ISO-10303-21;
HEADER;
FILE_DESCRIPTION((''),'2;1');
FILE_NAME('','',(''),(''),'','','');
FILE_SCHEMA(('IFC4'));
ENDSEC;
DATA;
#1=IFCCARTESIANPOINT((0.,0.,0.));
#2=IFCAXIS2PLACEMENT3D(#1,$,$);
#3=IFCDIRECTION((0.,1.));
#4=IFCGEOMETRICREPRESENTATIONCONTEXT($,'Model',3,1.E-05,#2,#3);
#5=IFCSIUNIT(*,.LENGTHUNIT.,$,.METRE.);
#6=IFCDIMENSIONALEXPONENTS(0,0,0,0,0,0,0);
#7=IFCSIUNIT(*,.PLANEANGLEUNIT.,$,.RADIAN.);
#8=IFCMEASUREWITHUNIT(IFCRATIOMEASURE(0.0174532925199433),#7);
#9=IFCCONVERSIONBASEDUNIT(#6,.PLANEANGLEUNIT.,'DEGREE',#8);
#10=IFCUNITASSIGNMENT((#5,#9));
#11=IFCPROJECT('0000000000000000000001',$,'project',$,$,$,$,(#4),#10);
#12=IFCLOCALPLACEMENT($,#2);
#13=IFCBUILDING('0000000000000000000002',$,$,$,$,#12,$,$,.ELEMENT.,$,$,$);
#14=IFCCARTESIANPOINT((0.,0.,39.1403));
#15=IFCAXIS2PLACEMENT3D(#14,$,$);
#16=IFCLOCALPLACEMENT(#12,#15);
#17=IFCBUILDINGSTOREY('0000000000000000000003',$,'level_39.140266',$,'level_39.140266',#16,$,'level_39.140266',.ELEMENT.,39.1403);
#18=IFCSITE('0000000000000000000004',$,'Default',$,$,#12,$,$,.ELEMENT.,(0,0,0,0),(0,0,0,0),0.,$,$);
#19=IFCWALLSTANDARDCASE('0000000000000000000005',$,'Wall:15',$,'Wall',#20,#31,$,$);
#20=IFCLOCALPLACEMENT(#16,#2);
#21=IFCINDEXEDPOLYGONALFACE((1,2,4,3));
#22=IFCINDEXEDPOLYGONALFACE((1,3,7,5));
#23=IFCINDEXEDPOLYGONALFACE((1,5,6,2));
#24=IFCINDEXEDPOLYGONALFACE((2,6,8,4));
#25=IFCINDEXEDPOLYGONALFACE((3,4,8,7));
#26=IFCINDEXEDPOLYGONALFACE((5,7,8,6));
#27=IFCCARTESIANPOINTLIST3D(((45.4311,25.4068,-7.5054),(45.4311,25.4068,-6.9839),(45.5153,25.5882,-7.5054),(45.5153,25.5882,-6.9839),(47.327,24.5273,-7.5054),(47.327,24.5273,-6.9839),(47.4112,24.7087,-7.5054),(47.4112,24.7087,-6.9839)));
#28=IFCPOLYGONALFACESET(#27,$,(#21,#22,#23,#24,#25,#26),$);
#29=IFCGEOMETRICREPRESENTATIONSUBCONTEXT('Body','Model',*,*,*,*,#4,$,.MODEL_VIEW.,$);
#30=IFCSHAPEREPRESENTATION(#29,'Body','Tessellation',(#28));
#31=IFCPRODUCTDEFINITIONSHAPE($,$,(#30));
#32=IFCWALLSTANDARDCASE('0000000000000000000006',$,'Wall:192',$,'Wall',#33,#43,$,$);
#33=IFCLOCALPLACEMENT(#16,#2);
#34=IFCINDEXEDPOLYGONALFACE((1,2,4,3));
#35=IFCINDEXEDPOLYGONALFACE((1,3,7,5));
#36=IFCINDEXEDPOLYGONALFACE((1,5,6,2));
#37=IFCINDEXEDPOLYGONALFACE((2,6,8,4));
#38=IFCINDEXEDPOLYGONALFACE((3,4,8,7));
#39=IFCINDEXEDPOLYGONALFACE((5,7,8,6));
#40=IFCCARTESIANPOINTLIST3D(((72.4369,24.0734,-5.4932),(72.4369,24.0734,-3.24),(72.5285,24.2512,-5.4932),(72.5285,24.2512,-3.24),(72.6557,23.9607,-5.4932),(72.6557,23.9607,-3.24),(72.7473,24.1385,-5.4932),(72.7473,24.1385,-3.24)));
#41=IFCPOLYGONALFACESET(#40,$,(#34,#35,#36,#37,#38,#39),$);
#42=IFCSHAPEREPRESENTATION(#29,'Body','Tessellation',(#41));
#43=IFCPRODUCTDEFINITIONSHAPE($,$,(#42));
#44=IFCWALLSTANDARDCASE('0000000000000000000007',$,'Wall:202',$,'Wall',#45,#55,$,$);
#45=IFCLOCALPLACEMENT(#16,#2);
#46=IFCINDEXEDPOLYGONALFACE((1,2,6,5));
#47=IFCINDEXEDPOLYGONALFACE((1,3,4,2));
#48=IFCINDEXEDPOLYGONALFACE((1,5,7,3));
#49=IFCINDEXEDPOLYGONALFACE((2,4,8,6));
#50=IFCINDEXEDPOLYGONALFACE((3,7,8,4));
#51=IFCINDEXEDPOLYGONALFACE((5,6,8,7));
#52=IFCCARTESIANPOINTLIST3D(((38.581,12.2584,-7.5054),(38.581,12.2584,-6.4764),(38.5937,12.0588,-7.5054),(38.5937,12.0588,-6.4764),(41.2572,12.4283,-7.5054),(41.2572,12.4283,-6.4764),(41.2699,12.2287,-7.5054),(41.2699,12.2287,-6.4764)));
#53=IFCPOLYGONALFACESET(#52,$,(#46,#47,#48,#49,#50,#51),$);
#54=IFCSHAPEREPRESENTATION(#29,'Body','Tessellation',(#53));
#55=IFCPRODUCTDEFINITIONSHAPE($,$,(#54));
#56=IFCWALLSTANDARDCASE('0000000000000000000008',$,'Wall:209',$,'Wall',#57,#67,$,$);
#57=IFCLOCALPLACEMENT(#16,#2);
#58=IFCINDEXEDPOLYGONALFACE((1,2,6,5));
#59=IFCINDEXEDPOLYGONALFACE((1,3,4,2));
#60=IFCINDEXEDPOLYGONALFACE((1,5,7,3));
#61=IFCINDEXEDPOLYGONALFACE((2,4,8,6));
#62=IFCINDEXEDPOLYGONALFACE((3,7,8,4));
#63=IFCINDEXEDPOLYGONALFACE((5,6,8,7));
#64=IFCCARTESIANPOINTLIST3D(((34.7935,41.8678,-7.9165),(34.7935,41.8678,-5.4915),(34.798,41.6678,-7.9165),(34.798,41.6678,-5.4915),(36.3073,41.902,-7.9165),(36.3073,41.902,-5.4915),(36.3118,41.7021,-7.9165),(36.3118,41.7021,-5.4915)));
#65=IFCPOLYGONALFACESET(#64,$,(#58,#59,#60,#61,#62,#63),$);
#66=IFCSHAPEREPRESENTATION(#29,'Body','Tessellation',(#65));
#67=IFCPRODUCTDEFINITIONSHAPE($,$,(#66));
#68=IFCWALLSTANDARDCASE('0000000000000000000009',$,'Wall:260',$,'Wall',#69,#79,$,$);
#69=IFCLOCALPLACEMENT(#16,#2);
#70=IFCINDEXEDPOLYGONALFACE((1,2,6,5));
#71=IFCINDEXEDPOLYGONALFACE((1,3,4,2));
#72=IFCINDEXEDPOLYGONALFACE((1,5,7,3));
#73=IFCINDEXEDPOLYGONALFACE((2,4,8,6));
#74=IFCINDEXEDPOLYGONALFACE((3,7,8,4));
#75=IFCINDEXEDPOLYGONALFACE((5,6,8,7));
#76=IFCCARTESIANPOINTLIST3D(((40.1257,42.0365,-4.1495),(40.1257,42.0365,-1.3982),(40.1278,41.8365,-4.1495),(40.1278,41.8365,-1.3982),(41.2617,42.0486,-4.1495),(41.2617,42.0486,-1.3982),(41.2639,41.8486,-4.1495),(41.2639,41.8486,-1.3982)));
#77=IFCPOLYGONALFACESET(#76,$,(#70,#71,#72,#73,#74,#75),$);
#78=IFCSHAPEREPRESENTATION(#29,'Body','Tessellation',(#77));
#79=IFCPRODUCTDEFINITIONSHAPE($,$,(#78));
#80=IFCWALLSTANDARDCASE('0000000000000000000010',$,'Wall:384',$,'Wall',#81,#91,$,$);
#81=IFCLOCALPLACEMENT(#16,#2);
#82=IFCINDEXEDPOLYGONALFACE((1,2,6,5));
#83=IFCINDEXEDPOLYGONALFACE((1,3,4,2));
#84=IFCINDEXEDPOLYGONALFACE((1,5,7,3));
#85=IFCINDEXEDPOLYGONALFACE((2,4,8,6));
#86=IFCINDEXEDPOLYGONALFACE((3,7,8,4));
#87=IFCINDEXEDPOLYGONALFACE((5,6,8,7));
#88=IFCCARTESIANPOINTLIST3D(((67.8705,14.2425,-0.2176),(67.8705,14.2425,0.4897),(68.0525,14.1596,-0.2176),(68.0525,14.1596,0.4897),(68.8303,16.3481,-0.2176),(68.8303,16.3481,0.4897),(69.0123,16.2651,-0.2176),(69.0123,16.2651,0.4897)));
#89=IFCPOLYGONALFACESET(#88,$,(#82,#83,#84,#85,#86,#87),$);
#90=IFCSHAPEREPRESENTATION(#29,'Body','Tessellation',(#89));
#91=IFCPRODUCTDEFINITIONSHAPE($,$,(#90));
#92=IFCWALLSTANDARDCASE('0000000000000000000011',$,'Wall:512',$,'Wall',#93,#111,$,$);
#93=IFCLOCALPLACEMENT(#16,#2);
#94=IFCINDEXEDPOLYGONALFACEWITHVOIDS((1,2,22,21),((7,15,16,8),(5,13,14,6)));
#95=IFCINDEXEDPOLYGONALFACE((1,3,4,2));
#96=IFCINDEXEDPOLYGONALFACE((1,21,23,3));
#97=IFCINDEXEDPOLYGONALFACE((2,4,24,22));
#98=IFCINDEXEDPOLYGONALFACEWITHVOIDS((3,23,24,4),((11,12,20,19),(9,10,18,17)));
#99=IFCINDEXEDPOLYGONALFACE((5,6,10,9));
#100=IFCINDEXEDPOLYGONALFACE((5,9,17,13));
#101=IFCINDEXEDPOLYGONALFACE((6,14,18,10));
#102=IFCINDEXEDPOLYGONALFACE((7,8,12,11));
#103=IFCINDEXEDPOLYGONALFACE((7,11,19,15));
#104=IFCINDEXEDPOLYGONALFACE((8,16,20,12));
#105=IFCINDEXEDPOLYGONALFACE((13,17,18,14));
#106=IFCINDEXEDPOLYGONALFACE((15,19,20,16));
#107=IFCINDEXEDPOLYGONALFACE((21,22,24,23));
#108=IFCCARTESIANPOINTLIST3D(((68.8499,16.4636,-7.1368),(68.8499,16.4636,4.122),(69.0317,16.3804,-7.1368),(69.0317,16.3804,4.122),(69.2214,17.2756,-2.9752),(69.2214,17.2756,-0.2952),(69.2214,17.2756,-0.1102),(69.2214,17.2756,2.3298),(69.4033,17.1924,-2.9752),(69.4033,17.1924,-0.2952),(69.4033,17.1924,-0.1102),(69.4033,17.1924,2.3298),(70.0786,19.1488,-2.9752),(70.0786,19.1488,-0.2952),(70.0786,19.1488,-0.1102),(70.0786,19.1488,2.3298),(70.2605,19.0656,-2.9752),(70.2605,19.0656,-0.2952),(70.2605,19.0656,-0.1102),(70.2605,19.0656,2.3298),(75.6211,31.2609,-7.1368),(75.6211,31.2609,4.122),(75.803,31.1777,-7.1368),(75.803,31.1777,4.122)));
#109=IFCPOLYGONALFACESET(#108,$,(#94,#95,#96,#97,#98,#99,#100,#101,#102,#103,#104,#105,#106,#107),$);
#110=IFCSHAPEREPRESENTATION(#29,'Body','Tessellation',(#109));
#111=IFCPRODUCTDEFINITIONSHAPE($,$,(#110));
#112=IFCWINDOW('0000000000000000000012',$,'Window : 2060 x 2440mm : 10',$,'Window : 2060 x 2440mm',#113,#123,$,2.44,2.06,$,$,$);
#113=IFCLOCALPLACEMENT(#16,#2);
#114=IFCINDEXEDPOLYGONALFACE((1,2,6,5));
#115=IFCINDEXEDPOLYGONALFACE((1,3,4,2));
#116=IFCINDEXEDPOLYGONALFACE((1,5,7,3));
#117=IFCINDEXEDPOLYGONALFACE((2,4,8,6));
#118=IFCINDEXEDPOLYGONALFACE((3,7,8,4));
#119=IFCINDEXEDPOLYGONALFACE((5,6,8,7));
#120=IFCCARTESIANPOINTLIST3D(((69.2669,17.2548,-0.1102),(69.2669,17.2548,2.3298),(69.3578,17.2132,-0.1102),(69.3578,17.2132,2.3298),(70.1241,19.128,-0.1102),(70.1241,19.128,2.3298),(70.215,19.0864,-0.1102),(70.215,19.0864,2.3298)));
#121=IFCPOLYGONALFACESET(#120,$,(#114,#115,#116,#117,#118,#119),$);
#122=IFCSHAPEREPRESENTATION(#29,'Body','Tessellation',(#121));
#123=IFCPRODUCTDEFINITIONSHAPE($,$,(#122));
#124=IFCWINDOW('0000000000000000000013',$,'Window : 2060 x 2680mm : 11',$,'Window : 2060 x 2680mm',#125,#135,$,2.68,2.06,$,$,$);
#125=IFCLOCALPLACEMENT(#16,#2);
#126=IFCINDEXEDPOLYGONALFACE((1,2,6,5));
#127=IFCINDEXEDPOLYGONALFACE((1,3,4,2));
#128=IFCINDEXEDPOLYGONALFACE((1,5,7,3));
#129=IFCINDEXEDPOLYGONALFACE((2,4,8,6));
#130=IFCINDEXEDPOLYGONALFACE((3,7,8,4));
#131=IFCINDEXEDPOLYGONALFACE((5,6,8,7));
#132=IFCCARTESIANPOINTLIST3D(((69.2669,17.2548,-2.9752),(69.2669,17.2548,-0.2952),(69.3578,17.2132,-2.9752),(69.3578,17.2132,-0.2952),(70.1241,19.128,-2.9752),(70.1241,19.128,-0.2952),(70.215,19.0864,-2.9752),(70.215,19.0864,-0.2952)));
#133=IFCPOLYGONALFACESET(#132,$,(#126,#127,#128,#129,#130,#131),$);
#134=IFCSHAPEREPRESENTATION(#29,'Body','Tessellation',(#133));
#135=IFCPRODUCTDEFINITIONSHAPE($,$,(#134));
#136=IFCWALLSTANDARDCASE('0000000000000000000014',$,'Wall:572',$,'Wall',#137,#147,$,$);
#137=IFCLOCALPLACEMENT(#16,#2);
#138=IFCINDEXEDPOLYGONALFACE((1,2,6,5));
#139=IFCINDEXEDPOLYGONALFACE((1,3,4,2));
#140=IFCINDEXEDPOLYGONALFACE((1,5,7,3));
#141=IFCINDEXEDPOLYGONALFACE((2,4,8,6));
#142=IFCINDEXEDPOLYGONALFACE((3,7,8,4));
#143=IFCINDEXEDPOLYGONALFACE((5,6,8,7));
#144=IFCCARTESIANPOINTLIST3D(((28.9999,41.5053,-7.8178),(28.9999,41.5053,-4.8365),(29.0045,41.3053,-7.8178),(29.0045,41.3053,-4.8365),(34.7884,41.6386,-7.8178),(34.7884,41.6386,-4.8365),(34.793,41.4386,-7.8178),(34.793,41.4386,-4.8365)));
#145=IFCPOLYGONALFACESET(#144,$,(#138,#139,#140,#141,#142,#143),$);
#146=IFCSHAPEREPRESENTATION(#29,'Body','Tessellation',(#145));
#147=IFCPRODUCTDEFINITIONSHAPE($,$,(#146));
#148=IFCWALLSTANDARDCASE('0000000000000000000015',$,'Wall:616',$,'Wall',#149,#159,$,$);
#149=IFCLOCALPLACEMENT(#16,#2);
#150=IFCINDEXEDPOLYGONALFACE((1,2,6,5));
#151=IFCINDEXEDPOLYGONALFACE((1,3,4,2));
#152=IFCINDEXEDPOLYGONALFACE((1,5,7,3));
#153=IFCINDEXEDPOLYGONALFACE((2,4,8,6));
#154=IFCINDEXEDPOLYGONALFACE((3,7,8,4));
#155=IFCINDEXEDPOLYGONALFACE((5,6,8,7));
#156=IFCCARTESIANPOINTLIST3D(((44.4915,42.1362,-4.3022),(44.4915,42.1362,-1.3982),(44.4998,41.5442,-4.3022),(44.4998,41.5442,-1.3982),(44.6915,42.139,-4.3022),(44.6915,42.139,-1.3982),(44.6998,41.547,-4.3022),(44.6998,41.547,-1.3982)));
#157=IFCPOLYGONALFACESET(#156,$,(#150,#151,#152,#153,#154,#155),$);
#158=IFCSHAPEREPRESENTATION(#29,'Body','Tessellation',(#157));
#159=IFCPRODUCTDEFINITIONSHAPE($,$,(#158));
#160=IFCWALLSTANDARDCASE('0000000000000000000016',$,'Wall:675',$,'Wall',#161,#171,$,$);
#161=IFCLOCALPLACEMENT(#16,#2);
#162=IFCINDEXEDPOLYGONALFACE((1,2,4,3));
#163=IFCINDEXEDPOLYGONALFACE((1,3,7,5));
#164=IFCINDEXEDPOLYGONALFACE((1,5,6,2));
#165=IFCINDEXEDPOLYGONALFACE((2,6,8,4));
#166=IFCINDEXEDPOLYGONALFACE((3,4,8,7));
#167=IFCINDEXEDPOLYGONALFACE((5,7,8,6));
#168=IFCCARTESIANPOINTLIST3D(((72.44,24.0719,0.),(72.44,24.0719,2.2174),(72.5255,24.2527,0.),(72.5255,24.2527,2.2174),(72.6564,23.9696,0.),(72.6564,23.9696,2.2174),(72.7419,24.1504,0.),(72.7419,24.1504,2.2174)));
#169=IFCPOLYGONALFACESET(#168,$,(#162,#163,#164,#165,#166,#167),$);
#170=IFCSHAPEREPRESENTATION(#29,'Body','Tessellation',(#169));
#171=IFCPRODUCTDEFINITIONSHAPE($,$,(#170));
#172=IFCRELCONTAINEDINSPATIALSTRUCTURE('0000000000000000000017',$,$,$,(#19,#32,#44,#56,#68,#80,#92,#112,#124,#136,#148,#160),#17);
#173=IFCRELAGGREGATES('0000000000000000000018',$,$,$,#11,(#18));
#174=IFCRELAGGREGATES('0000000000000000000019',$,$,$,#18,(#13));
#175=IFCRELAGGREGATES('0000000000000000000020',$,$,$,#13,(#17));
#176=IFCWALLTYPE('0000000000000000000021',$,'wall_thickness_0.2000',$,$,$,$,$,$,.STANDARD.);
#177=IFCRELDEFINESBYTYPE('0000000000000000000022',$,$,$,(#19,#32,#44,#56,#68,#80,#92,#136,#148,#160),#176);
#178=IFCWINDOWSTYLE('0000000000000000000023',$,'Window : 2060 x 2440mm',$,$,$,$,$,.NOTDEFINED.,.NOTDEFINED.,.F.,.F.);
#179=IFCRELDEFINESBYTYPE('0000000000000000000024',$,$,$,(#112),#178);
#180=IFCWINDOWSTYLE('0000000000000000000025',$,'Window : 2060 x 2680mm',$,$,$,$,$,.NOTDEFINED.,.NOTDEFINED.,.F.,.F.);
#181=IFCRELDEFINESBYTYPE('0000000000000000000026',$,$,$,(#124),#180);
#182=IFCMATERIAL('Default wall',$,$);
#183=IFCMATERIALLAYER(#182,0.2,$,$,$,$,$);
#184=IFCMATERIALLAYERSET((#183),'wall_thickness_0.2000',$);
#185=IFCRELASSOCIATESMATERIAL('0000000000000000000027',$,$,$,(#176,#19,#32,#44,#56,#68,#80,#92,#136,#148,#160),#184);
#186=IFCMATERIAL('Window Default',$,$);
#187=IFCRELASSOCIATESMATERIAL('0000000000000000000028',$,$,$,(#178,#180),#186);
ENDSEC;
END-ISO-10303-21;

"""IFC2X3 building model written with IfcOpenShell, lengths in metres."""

from ifc_helpers import new_model, entity, si_unit, converted_unit, direction, frame, frame_2d, origin, origin_2d_with_axis, place, context, subcontext, project, spatial, polyline, rectangle, outline, extrude, source, transform, mapped, material, layer, layer_set, layer_usage, type_object, type_shapes, element, fill, save


model = new_model("IFC2X3")

# Units and contexts
model_context = context("Model", 3, precision=1e-05, world=origin(), true_north=direction((0.0, 1.0)))
body_context = subcontext(model_context, "Body", "Model", "MODEL_VIEW")
ifc_project = project(units=[si_unit("LENGTHUNIT", "METRE"), converted_unit("PLANEANGLEUNIT", "DEGREE", entity("IfcRatioMeasure", 0.0174532925199433), si_unit("PLANEANGLEUNIT", "RADIAN"), dimensions=[0, 0, 0, 0, 0, 0, 0])], contexts=[model_context])

# Site, building, storey
placement_1 = place(None, origin())
site = spatial("IfcSite", under=ifc_project, at=placement_1, Name="Default", CompositionType="ELEMENT", RefLatitude=(0, 0, 0, 0), RefLongitude=(0, 0, 0, 0), RefElevation=0.0)
building = spatial("IfcBuilding", under=site, at=placement_1, CompositionType="ELEMENT")
storey_placement = place(placement_1, frame((0.0, 0.0, 39.1403)))
storey = spatial("IfcBuildingStorey", under=building, at=storey_placement, Name="level_39.140266", ObjectType="level_39.140266", LongName="level_39.140266", CompositionType="ELEMENT", Elevation=39.1403)

# Walls
ifc_material_1 = material(Name="Default wall")
ifc_layer = layer(ifc_material_1, 0.2)
ifc_layer_set = layer_set([ifc_layer], Name="wall_thickness_0.2000")
ifc_layer_usage = layer_usage(ifc_layer_set, "AXIS2", "POSITIVE", -0.1)
wall_type = type_object("IfcWallType", Name="wall_thickness_0.2000", PredefinedType="STANDARD", material=ifc_layer_set)
placement_2 = place(placement_1, frame((0.0, 0.0, 31.6349)))
wall_1_placement = place(placement_2, frame((45.4732, 25.4975, 0.0), z_axis=(0.0, 0.0, 1.0), x_axis=(0.907141, -0.420826, 0.0)))
element("IfcWallStandardCase", 1, at=wall_1_placement, inside=storey, type_object=wall_type, material=ifc_layer_usage, Name="Wall:15", ObjectType="Wall", context=body_context, shape_type="SweptSolid", body=[
    extrude(outline(polyline([(2.09, -0.1), (2.09, 0.1), (0.0, 0.1), (0.0, -0.1), (2.09, -0.1)])), origin(), (0.0, 0.0, 1.0), 0.5215),
])
placement_3 = place(placement_1, frame((0.0, 0.0, 33.6471)))
wall_2_placement = place(placement_3, frame((72.7015, 24.0496, 0.0), z_axis=(0.0, 0.0, 1.0), x_axis=(-0.888905, 0.458091, 0.0)))
element("IfcWallStandardCase", 2, at=wall_2_placement, inside=storey, type_object=wall_type, material=ifc_layer_usage, Name="Wall:192", ObjectType="Wall", context=body_context, shape_type="SweptSolid", body=[
    extrude(outline(polyline([(0.2461, -0.1), (0.2461, 0.1), (0.0, 0.1), (0.0, -0.1), (0.2461, -0.1)])), origin(), (0.0, 0.0, 1.0), 2.2533),
])
placement_4 = place(placement_1, frame((0.0, 0.0, 31.6349)))
wall_3_placement = place(placement_4, frame((38.5873, 12.1586, 0.0), z_axis=(0.0, 0.0, 1.0), x_axis=(0.99799, 0.063371, 0.0)))
element("IfcWallStandardCase", 3, at=wall_3_placement, inside=storey, type_object=wall_type, material=ifc_layer_usage, Name="Wall:202", ObjectType="Wall", context=body_context, shape_type="SweptSolid", body=[
    extrude(outline(polyline([(2.6816, -0.1), (2.6816, 0.1), (0.0, 0.1), (0.0, -0.1), (2.6816, -0.1)])), origin(), (0.0, 0.0, 1.0), 1.029),
])
placement_5 = place(placement_1, frame((0.0, 0.0, 31.2238)))
wall_4_placement = place(placement_5, frame((36.3095, 41.802, 0.0), z_axis=(0.0, 0.0, 1.0), x_axis=(-0.999744, -0.022609, 0.0)))
element("IfcWallStandardCase", 4, at=wall_4_placement, inside=storey, type_object=wall_type, material=ifc_layer_usage, Name="Wall:209", ObjectType="Wall", context=body_context, shape_type="SweptSolid", body=[
    extrude(outline(polyline([(1.5142, -0.1), (1.5142, 0.1), (0.0, 0.1), (0.0, -0.1), (1.5142, -0.1)])), origin(), (0.0, 0.0, 1.0), 2.4251),
])
placement_6 = place(placement_1, frame((0.0, 0.0, 34.9908)))
wall_5_placement = place(placement_6, frame((41.2628, 41.9486, 0.0), z_axis=(0.0, 0.0, 1.0), x_axis=(-0.999944, -0.010627, 0.0)))
element("IfcWallStandardCase", 5, at=wall_5_placement, inside=storey, type_object=wall_type, material=ifc_layer_usage, Name="Wall:260", ObjectType="Wall", context=body_context, shape_type="SweptSolid", body=[
    extrude(outline(polyline([(1.1361, -0.1), (1.1361, 0.1), (0.0, 0.1), (0.0, -0.1), (1.1361, -0.1)])), origin(), (0.0, 0.0, 1.0), 2.7513),
])
placement_7 = place(placement_1, frame((0.0, 0.0, 38.9227)))
wall_6_placement = place(placement_7, frame((67.9615, 14.2011, 0.0), z_axis=(0.0, 0.0, 1.0), x_axis=(0.41477, 0.909926, 0.0)))
element("IfcWallStandardCase", 6, at=wall_6_placement, inside=storey, type_object=wall_type, material=ifc_layer_usage, Name="Wall:384", ObjectType="Wall", context=body_context, shape_type="SweptSolid", body=[
    extrude(outline(polyline([(2.3139, -0.1), (2.3139, 0.1), (0.0, 0.1), (0.0, -0.1), (2.3139, -0.1)])), origin(), (0.0, 0.0, 1.0), 0.7074),
])

# Wall, openings, windows
placement_8 = place(placement_1, frame((0.0, 0.0, 32.0035)))
wall_7_placement = place(placement_8, frame((68.9408, 16.422, 0.0), z_axis=(0.0, 0.0, 1.0), x_axis=(0.416104, 0.909317, 0.0)))
wall_7 = element("IfcWallStandardCase", 7, at=wall_7_placement, inside=storey, type_object=wall_type, material=ifc_layer_usage, Name="Wall:512", ObjectType="Wall", context=body_context, shape_type="SweptSolid", body=[
    extrude(outline(polyline([(16.273, -0.1), (16.273, 0.1), (0.0, 0.1), (0.0, -0.1), (16.273, -0.1)])), origin(), (0.0, 0.0, 1.0), 11.2588),
])
opening_1_placement = place(wall_7_placement, frame((0.893, -0.1, 7.0266)))
opening_1 = element("IfcOpeningElement", 8, at=opening_1_placement, cuts=wall_7, ObjectType="Opening", context=body_context, shape_type="SweptSolid", body=[
    extrude(rectangle(XDim=2.06, YDim=2.44, at=frame_2d((1.22, 1.03), x_axis=(0.0, 1.0))), frame((0.0, 0.0, 0.0), z_axis=(0.0, 1.0, 0.0), x_axis=(0.0, 0.0, 1.0)), (0.0, 0.0, 1.0), 0.2),
])
opening_2_placement = place(wall_7_placement, frame((0.893, -0.1, 4.1616)))
opening_2 = element("IfcOpeningElement", 9, at=opening_2_placement, cuts=wall_7, ObjectType="Opening", context=body_context, shape_type="SweptSolid", body=[
    extrude(rectangle(XDim=2.06, YDim=2.68, at=frame_2d((1.34, 1.03), x_axis=(0.0, 1.0))), frame((0.0, 0.0, 0.0), z_axis=(0.0, 1.0, 0.0), x_axis=(0.0, 0.0, 1.0)), (0.0, 0.0, 1.0), 0.2),
])
ifc_material_2 = material(Name="Window Default")
window_style_1 = type_object("IfcWindowStyle", Name="Window : 2060 x 2440mm", ConstructionType="NOTDEFINED", OperationType="NOTDEFINED", ParameterTakesPrecedence=False, Sizeable=False, material=ifc_material_2)
shared_shape_1 = source(origin(), body_context, "Body", "SweptSolid", [
    extrude(rectangle(XDim=0.1, YDim=2.06, at=origin_2d_with_axis()), frame((1.03, 0.1, 0.0), z_axis=(0.0, 0.0, 1.0), x_axis=(0.0, 1.0, 0.0)), (0.0, 0.0, 1.0), 2.44),
])
type_shapes(window_style_1, [shared_shape_1])
window_1_placement = place(opening_1_placement, origin())
window_1 = element("IfcWindow", 10, at=window_1_placement, inside=storey, type_object=window_style_1, Name="Window : 2060 x 2440mm : 10", ObjectType="Window : 2060 x 2440mm", OverallHeight=2.44, OverallWidth=2.06, context=body_context, shape_type="MappedRepresentation", body=[
    mapped(shared_shape_1, transform((0.0, 0.0, 0.0), scale=1.0)),
])
fill(opening_1, window_1)
window_style_2 = type_object("IfcWindowStyle", Name="Window : 2060 x 2680mm", ConstructionType="NOTDEFINED", OperationType="NOTDEFINED", ParameterTakesPrecedence=False, Sizeable=False, material=ifc_material_2)
shared_shape_2 = source(origin(), body_context, "Body", "SweptSolid", [
    extrude(rectangle(XDim=0.1, YDim=2.06, at=origin_2d_with_axis()), frame((1.03, 0.1, 0.0), z_axis=(0.0, 0.0, 1.0), x_axis=(0.0, 1.0, 0.0)), (0.0, 0.0, 1.0), 2.68),
])
type_shapes(window_style_2, [shared_shape_2])
window_2_placement = place(opening_2_placement, origin())
window_2 = element("IfcWindow", 11, at=window_2_placement, inside=storey, type_object=window_style_2, Name="Window : 2060 x 2680mm : 11", ObjectType="Window : 2060 x 2680mm", OverallHeight=2.68, OverallWidth=2.06, context=body_context, shape_type="MappedRepresentation", body=[
    mapped(shared_shape_2, transform((0.0, 0.0, 0.0), scale=1.0)),
])
fill(opening_2, window_2)

# Walls
placement_9 = place(placement_1, frame((0.0, 0.0, 31.3225)))
wall_8_placement = place(placement_9, frame((29.0022, 41.4053, 0.0), z_axis=(0.0, 0.0, 1.0), x_axis=(0.999735, 0.023025, 0.0)))
element("IfcWallStandardCase", 12, at=wall_8_placement, inside=storey, type_object=wall_type, material=ifc_layer_usage, Name="Wall:572", ObjectType="Wall", context=body_context, shape_type="SweptSolid", body=[
    extrude(outline(polyline([(5.79, -0.1), (5.79, 0.1), (0.0, 0.1), (0.0, -0.1), (5.79, -0.1)])), origin(), (0.0, 0.0, 1.0), 2.9812),
])
placement_10 = place(placement_1, frame((0.0, 0.0, 34.8381)))
wall_9_placement = place(placement_10, frame((44.5998, 41.5456, 0.0), z_axis=(0.0, 0.0, 1.0), x_axis=(-0.014001, 0.999902, 0.0)))
element("IfcWallStandardCase", 13, at=wall_9_placement, inside=storey, type_object=wall_type, material=ifc_layer_usage, Name="Wall:616", ObjectType="Wall", context=body_context, shape_type="SweptSolid", body=[
    extrude(outline(polyline([(0.5921, -0.1), (0.5921, 0.1), (0.0, 0.1), (0.0, -0.1), (0.5921, -0.1)])), origin(), (0.0, 0.0, 1.0), 2.9041),
])
wall_10_placement = place(storey_placement, frame((72.4828, 24.1623, 0.0), z_axis=(0.0, 0.0, 1.0), x_axis=(0.903998, -0.427537, 0.0)))
element("IfcWallStandardCase", 14, at=wall_10_placement, inside=storey, type_object=wall_type, material=ifc_layer_usage, Name="Wall:675", ObjectType="Wall", context=body_context, shape_type="SweptSolid", body=[
    extrude(outline(polyline([(0.2394, -0.1), (0.2394, 0.1), (0.0, 0.1), (0.0, -0.1), (0.2394, -0.1)])), origin(), (0.0, 0.0, 1.0), 2.2174),
])

save(model, "model.ifc")
